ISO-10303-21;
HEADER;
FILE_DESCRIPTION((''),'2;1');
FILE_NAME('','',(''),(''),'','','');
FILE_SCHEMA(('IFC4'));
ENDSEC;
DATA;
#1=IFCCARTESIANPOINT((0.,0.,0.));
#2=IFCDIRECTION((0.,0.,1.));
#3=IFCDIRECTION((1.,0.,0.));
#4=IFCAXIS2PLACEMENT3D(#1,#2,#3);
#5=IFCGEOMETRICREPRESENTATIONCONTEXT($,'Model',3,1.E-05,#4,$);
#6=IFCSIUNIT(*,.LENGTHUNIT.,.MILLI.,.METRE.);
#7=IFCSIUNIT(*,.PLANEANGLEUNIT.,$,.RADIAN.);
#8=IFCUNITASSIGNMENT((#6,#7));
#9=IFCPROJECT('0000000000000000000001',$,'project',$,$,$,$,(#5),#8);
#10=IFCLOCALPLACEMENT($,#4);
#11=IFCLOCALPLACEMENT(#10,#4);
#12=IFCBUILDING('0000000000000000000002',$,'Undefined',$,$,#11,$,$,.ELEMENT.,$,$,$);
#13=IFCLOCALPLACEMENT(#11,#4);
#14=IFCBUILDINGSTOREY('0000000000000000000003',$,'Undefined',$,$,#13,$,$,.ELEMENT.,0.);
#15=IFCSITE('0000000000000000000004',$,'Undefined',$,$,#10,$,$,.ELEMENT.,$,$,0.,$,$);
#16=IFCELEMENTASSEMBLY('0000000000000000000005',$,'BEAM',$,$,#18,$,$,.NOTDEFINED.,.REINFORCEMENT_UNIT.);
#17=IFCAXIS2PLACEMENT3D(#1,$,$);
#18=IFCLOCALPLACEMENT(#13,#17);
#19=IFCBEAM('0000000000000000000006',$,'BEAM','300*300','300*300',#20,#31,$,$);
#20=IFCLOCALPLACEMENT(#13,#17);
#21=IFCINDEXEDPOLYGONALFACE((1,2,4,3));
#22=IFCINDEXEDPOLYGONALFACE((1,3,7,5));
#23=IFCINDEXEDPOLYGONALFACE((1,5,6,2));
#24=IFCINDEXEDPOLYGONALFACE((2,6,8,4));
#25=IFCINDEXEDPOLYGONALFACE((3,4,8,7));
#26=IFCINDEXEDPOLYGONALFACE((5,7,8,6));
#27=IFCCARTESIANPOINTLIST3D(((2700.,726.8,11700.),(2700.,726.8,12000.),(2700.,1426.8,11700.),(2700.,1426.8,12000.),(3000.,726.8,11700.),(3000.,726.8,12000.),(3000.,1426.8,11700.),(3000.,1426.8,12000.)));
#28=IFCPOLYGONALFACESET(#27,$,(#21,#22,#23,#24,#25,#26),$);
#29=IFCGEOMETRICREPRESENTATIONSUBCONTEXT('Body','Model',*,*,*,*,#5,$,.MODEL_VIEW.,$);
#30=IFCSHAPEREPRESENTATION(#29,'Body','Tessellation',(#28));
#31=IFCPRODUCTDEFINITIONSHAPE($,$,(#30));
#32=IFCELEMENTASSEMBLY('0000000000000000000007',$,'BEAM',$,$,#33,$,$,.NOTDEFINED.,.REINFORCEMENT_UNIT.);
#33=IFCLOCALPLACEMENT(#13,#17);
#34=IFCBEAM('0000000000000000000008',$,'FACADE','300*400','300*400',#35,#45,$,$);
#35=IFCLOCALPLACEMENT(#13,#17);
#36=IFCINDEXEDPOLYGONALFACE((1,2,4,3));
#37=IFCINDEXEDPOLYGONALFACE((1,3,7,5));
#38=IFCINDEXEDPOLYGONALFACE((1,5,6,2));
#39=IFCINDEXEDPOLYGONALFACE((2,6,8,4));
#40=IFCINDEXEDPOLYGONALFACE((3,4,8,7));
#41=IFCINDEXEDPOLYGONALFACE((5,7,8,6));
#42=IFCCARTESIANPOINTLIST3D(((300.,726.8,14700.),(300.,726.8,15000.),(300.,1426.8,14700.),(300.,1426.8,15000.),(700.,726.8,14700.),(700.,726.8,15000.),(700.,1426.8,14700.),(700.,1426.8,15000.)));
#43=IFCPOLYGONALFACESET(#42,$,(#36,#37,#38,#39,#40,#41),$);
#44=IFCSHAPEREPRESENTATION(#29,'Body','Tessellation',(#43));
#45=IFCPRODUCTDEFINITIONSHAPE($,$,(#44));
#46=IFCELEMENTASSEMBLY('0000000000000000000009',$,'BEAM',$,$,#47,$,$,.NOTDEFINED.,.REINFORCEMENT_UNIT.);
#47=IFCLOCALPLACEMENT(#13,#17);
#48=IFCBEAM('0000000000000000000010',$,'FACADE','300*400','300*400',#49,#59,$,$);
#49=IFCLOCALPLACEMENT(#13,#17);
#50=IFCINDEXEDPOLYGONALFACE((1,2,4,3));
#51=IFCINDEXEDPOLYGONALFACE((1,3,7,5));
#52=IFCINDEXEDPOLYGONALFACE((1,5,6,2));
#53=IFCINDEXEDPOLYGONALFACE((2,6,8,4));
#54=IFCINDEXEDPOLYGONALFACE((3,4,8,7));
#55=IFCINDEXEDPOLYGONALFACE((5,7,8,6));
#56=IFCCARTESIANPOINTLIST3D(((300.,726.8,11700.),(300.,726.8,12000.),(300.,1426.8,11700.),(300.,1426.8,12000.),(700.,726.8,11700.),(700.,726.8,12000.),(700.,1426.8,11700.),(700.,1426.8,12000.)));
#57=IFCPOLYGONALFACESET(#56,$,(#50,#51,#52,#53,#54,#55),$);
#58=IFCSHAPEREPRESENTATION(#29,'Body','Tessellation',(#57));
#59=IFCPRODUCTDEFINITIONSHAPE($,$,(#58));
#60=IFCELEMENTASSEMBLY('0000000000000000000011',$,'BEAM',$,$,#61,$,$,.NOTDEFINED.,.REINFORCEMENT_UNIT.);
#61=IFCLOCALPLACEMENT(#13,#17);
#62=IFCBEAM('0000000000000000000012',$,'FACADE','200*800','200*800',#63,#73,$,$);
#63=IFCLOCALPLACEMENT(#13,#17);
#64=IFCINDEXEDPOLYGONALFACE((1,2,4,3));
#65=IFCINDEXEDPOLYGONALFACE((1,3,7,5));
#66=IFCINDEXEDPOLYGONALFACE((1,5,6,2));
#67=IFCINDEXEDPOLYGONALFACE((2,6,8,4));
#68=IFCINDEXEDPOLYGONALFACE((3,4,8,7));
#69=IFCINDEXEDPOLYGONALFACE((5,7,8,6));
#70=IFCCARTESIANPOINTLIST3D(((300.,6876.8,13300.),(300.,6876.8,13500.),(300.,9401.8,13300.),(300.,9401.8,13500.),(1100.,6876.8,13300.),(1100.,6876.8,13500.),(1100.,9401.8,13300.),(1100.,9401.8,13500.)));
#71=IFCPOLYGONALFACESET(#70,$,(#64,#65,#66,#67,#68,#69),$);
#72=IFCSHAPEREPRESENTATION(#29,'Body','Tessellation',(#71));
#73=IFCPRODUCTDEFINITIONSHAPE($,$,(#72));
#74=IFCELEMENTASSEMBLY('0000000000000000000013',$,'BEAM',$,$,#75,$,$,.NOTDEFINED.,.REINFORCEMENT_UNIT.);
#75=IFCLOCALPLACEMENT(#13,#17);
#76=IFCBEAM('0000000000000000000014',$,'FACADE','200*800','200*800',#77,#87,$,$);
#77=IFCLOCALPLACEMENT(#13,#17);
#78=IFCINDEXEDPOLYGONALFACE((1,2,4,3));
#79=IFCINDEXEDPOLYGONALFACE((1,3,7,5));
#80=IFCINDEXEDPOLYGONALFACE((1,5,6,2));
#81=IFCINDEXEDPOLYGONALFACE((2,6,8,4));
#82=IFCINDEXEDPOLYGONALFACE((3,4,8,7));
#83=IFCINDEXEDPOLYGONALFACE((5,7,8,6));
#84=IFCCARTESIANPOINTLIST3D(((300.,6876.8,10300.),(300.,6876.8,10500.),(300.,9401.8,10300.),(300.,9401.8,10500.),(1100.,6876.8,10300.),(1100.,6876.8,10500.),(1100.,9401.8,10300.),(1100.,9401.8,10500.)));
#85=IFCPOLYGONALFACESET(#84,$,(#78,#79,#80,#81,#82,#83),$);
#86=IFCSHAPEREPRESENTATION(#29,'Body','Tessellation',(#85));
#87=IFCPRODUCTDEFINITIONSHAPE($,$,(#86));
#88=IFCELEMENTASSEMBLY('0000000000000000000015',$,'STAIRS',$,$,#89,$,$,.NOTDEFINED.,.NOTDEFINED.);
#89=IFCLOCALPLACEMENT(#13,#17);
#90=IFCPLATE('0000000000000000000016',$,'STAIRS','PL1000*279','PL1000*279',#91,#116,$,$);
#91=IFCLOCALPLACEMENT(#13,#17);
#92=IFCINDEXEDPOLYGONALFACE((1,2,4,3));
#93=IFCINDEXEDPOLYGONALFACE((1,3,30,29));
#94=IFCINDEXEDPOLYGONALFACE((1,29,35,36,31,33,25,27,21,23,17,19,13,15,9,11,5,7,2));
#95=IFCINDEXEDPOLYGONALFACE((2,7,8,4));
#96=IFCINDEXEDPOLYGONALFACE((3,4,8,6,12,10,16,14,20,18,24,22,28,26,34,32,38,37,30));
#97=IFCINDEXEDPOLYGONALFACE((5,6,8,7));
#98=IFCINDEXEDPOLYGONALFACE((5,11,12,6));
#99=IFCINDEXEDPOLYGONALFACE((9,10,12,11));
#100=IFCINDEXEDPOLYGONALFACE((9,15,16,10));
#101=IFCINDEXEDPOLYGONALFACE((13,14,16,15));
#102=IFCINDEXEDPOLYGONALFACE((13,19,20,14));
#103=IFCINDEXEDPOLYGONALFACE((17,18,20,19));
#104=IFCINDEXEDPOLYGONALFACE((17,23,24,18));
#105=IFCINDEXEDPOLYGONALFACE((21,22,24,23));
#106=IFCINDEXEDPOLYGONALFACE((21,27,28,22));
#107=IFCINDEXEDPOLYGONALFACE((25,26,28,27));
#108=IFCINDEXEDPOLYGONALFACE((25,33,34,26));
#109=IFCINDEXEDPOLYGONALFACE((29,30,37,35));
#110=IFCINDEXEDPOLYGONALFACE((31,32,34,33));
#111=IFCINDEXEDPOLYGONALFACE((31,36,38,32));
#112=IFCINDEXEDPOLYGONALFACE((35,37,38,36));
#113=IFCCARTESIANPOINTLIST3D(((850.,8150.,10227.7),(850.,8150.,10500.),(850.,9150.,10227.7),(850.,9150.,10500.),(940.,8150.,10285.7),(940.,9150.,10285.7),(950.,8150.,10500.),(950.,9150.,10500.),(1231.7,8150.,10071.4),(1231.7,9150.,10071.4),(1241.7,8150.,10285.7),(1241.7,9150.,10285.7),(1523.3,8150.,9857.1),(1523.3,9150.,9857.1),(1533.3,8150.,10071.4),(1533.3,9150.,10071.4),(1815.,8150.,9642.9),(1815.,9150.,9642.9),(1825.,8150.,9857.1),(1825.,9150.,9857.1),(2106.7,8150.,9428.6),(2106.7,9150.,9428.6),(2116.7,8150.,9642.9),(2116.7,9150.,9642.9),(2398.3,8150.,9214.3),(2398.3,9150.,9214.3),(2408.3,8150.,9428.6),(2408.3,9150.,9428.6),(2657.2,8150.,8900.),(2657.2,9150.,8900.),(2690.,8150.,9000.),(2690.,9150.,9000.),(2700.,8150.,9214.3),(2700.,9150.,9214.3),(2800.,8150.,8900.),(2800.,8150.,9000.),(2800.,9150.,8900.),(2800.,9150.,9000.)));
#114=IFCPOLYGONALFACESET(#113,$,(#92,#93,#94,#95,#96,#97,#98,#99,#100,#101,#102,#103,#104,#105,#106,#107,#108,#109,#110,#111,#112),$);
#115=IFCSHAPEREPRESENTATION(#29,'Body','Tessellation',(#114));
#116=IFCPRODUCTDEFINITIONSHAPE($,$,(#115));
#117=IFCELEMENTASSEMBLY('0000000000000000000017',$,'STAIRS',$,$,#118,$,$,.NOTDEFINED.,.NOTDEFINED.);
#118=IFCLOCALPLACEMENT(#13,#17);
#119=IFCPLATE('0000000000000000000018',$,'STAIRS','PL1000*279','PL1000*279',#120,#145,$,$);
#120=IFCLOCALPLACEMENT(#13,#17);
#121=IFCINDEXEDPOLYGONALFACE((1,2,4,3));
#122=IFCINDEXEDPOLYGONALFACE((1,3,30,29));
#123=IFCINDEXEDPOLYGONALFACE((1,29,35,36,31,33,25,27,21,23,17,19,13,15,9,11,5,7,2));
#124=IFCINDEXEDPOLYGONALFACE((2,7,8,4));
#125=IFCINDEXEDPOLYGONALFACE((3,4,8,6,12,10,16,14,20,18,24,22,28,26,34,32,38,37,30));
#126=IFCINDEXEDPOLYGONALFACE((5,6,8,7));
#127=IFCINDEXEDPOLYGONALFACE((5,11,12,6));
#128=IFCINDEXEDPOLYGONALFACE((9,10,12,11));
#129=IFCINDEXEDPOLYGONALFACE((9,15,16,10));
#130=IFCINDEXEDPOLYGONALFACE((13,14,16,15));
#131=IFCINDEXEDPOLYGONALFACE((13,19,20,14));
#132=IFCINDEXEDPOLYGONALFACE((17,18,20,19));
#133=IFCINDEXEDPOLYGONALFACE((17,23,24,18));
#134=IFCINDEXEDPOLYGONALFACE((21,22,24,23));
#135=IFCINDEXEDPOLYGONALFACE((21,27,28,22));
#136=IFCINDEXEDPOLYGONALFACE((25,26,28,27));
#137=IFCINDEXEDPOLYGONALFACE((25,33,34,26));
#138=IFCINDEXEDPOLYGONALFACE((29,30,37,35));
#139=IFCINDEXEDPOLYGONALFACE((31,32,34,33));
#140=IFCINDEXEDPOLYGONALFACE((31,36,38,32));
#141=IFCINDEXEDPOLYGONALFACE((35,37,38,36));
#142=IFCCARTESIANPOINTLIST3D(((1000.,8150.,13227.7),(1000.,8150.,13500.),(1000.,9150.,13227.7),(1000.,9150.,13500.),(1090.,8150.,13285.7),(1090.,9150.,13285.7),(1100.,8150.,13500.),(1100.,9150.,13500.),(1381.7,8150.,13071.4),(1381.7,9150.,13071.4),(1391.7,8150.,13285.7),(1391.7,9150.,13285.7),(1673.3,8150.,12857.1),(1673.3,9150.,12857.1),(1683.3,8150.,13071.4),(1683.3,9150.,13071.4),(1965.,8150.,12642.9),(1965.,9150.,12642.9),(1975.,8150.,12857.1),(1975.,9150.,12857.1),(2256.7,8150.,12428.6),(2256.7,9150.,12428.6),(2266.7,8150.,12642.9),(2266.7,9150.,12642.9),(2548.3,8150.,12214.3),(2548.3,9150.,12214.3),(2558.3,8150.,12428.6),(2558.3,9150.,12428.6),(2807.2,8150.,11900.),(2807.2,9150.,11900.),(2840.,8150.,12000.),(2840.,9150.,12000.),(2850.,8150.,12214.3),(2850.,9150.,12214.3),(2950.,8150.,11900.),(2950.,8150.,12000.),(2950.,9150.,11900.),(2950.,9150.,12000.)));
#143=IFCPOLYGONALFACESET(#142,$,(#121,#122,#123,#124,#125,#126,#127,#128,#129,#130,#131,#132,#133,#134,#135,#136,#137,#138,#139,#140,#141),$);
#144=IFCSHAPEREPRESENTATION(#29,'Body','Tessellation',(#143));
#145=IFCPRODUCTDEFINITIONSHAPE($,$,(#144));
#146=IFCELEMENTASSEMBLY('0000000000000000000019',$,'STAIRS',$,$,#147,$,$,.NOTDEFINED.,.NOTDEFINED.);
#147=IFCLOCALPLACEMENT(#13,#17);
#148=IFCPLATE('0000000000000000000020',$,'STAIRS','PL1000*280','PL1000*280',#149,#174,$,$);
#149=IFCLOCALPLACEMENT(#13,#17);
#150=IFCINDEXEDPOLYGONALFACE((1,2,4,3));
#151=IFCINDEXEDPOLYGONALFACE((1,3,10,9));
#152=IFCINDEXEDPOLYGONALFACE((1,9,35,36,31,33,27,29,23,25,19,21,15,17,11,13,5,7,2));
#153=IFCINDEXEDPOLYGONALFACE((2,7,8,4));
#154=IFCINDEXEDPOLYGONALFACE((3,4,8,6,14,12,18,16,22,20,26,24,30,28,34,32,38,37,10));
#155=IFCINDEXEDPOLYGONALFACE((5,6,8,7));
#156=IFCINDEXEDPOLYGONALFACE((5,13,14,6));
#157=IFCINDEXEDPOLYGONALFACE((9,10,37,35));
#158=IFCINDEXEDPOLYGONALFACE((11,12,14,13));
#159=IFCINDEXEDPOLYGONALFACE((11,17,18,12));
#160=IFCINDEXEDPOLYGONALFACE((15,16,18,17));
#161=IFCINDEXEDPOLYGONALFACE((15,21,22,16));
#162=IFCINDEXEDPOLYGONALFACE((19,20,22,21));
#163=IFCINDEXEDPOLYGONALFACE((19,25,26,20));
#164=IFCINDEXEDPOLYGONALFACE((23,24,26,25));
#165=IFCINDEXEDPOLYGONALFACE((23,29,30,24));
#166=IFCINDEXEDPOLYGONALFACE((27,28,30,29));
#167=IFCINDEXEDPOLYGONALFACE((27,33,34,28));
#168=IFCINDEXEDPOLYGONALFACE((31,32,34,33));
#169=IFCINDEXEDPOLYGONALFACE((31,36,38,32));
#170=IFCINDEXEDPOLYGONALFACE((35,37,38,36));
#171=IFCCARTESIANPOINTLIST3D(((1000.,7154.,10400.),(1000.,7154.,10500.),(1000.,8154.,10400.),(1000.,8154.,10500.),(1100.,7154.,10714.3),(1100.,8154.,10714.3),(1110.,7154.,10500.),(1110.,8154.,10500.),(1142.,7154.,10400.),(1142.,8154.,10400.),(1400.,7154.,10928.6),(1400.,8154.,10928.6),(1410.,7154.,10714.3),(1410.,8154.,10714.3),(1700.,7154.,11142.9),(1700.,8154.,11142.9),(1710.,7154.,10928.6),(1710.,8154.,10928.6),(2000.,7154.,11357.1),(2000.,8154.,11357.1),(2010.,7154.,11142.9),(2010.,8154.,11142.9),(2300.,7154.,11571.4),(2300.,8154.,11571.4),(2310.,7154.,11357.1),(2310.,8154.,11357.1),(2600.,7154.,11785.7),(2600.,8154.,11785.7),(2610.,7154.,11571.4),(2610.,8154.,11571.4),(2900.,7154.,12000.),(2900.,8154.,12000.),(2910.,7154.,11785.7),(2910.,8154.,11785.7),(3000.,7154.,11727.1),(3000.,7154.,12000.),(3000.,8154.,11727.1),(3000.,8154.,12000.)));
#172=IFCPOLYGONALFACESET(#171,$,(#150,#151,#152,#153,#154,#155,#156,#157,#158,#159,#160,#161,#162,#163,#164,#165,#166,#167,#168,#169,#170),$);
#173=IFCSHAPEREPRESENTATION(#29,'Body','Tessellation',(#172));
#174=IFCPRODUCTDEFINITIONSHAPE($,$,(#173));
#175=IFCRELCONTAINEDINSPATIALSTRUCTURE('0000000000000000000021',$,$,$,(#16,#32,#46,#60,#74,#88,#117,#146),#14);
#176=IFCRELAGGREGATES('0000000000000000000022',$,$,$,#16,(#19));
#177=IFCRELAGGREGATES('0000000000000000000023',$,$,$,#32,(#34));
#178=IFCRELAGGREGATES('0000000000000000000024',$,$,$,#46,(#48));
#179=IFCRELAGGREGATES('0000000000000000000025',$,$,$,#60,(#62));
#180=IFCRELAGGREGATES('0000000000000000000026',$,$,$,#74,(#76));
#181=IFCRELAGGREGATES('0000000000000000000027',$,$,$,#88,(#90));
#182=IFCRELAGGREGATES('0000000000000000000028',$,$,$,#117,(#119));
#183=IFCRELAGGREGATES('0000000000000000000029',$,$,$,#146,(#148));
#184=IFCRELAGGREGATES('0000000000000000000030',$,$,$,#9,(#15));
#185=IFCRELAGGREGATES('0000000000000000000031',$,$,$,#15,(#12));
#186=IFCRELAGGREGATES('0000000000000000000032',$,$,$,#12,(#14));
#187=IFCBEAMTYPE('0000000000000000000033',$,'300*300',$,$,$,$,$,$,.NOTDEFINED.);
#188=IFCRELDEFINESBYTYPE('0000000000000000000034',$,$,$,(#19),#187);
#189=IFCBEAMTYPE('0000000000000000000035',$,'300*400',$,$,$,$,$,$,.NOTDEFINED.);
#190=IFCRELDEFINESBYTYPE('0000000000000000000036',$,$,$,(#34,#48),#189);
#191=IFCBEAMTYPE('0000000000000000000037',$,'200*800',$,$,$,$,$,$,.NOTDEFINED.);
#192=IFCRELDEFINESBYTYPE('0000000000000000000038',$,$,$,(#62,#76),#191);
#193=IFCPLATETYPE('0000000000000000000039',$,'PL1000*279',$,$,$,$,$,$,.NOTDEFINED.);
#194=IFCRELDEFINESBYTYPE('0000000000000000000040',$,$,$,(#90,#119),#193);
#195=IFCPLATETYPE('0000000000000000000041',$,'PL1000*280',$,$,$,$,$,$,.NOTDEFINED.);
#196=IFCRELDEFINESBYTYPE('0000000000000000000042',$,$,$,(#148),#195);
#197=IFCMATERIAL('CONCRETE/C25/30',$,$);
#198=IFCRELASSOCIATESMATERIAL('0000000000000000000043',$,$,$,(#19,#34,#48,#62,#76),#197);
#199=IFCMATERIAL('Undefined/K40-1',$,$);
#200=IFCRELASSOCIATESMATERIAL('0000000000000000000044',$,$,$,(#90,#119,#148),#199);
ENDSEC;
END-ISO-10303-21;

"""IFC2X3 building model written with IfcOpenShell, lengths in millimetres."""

from ifc_helpers import new_model, si_unit, frame, origin_with_axes, origin_2d_with_axis, place, context, subcontext, project, spatial, polyline, rectangle, outline, extrude, material, type_object, element, aggregate, save


model = new_model("IFC2X3")

# Units and contexts
model_context = context("Model", 3, precision=1e-05, world=origin_with_axes())
body_context = subcontext(model_context, "Body", "Model", "MODEL_VIEW")
ifc_project = project(units=[si_unit("LENGTHUNIT", "METRE", prefix="MILLI"), si_unit("PLANEANGLEUNIT", "RADIAN")], contexts=[model_context])

# Site, building, storey
site_placement = place(None, origin_with_axes())
site = spatial("IfcSite", under=ifc_project, at=site_placement, Name="Undefined", CompositionType="ELEMENT", RefElevation=0.0)
building_placement = place(site_placement, origin_with_axes())
building = spatial("IfcBuilding", under=site, at=building_placement, Name="Undefined", CompositionType="ELEMENT")
storey_placement = place(building_placement, origin_with_axes())
storey = spatial("IfcBuildingStorey", under=building, at=storey_placement, Name="Undefined", CompositionType="ELEMENT", Elevation=0.0)

# Shared definitions
ifc_material_1 = material(Name="CONCRETE/C25/30")

# Element assemblies, beams
beam_type_1 = type_object("IfcBeamType", Name="300*300", PredefinedType="NOTDEFINED")
assembly_1_placement = place(storey_placement, origin_with_axes())
assembly_1 = element("IfcElementAssembly", 1, at=assembly_1_placement, inside=storey, Name="BEAM", AssemblyPlace="NOTDEFINED", PredefinedType="REINFORCEMENT_UNIT")
beam_1_placement = place(assembly_1_placement, frame((2850.0, 1426.8, 11850.0), z_axis=(0.0, 0.0, 1.0), x_axis=(0.0, -1.0, 0.0)))
beam_1 = element("IfcBeam", 2, at=beam_1_placement, type_object=beam_type_1, material=ifc_material_1, Name="BEAM", Description="300*300", ObjectType="300*300", context=body_context, shape_type="SweptSolid", body=[
    extrude(rectangle(XDim=300.0, YDim=300.0, at=origin_2d_with_axis()), frame((700.0, 0.0, 0.0), z_axis=(-1.0, 0.0, 0.0), x_axis=(0.0, -1.0, 0.0)), (0.0, 0.0, 1.0), 700.0),
])
aggregate(assembly_1, [beam_1])
assembly_2_placement = place(storey_placement, origin_with_axes())
assembly_2 = element("IfcElementAssembly", 3, at=assembly_2_placement, inside=storey, Name="BEAM", AssemblyPlace="NOTDEFINED", PredefinedType="REINFORCEMENT_UNIT")
beam_type_2 = type_object("IfcBeamType", Name="300*400", PredefinedType="NOTDEFINED")
beam_2_placement = place(assembly_2_placement, frame((500.0, 1426.8, 14850.0), z_axis=(0.0, 0.0, 1.0), x_axis=(0.0, -1.0, 0.0)))
beam_2 = element("IfcBeam", 4, at=beam_2_placement, type_object=beam_type_2, material=ifc_material_1, Name="FACADE", Description="300*400", ObjectType="300*400", context=body_context, shape_type="SweptSolid", body=[
    extrude(rectangle(XDim=400.0, YDim=300.0, at=origin_2d_with_axis()), frame((700.0, 0.0, 0.0), z_axis=(-1.0, 0.0, 0.0), x_axis=(0.0, -1.0, 0.0)), (0.0, 0.0, 1.0), 700.0),
])
aggregate(assembly_2, [beam_2])
assembly_3_placement = place(storey_placement, origin_with_axes())
assembly_3 = element("IfcElementAssembly", 5, at=assembly_3_placement, inside=storey, Name="BEAM", AssemblyPlace="NOTDEFINED", PredefinedType="REINFORCEMENT_UNIT")
beam_3_placement = place(assembly_3_placement, frame((500.0, 1426.8, 11850.0), z_axis=(0.0, 0.0, 1.0), x_axis=(0.0, -1.0, 0.0)))
beam_3 = element("IfcBeam", 6, at=beam_3_placement, type_object=beam_type_2, material=ifc_material_1, Name="FACADE", Description="300*400", ObjectType="300*400", context=body_context, shape_type="SweptSolid", body=[
    extrude(rectangle(XDim=400.0, YDim=300.0, at=origin_2d_with_axis()), frame((700.0, 0.0, 0.0), z_axis=(-1.0, 0.0, 0.0), x_axis=(0.0, -1.0, 0.0)), (0.0, 0.0, 1.0), 700.0),
])
aggregate(assembly_3, [beam_3])
assembly_4_placement = place(storey_placement, origin_with_axes())
assembly_4 = element("IfcElementAssembly", 7, at=assembly_4_placement, inside=storey, Name="BEAM", AssemblyPlace="NOTDEFINED", PredefinedType="REINFORCEMENT_UNIT")
beam_type_3 = type_object("IfcBeamType", Name="200*800", PredefinedType="NOTDEFINED")
beam_4_placement = place(assembly_4_placement, frame((700.0, 9401.8, 13400.0), z_axis=(0.0, 0.0, 1.0), x_axis=(0.0, -1.0, 0.0)))
beam_4 = element("IfcBeam", 8, at=beam_4_placement, type_object=beam_type_3, material=ifc_material_1, Name="FACADE", Description="200*800", ObjectType="200*800", context=body_context, shape_type="SweptSolid", body=[
    extrude(rectangle(XDim=800.0, YDim=200.0, at=origin_2d_with_axis()), frame((2525.0, 0.0, 0.0), z_axis=(-1.0, 0.0, 0.0), x_axis=(0.0, -1.0, 0.0)), (0.0, 0.0, 1.0), 2525.0),
])
aggregate(assembly_4, [beam_4])
assembly_5_placement = place(storey_placement, origin_with_axes())
assembly_5 = element("IfcElementAssembly", 9, at=assembly_5_placement, inside=storey, Name="BEAM", AssemblyPlace="NOTDEFINED", PredefinedType="REINFORCEMENT_UNIT")
beam_5_placement = place(assembly_5_placement, frame((700.0, 9401.8, 10400.0), z_axis=(0.0, 0.0, 1.0), x_axis=(0.0, -1.0, 0.0)))
beam_5 = element("IfcBeam", 10, at=beam_5_placement, type_object=beam_type_3, material=ifc_material_1, Name="FACADE", Description="200*800", ObjectType="200*800", context=body_context, shape_type="SweptSolid", body=[
    extrude(rectangle(XDim=800.0, YDim=200.0, at=origin_2d_with_axis()), frame((2525.0, 0.0, 0.0), z_axis=(-1.0, 0.0, 0.0), x_axis=(0.0, -1.0, 0.0)), (0.0, 0.0, 1.0), 2525.0),
])
aggregate(assembly_5, [beam_5])

# Element assemblies, plates
assembly_6_placement = place(storey_placement, origin_with_axes())
assembly_6 = element("IfcElementAssembly", 11, at=assembly_6_placement, inside=storey, Name="STAIRS", AssemblyPlace="NOTDEFINED", PredefinedType="NOTDEFINED")
ifc_material_2 = material(Name="Undefined/K40-1")
plate_type_1 = type_object("IfcPlateType", Name="PL1000*279", PredefinedType="NOTDEFINED")
plate_1_placement = place(assembly_6_placement, frame((2690.0, 8650.0, 9000.0), z_axis=(0.0, 1.0, 0.0), x_axis=(1.0, 0.0, 0.0)))
plate_1 = element("IfcPlate", 12, at=plate_1_placement, type_object=plate_type_1, material=ifc_material_2, Name="STAIRS", Description="PL1000*279", ObjectType="PL1000*279", context=body_context, shape_type="SweptSolid", body=[
    extrude(outline(polyline([(0.0, 0.0), (110.0, 0.0), (110.0, 100.0), (-32.8, 100.0), (-1840.0, -1227.7), (-1840.0, -1500.0), (-1740.0, -1500.0), (-1750.0, -1285.7), (-1448.3, -1285.7), (-1458.3, -1071.4), (-1156.7, -1071.4), (-1166.7, -857.1), (-865.0, -857.1), (-875.0, -642.9), (-573.3, -642.9), (-583.3, -428.6), (-281.7, -428.6), (-291.7, -214.3), (10.0, -214.3), (0.0, 0.0), (0.0, 0.0)])), frame((0.0, 0.0, -500.0), z_axis=(0.0, 0.0, 1.0), x_axis=(1.0, 0.0, 0.0)), (0.0, 0.0, 1.0), 1000.0),
])
aggregate(assembly_6, [plate_1])
assembly_7_placement = place(storey_placement, origin_with_axes())
assembly_7 = element("IfcElementAssembly", 13, at=assembly_7_placement, inside=storey, Name="STAIRS", AssemblyPlace="NOTDEFINED", PredefinedType="NOTDEFINED")
plate_2_placement = place(assembly_7_placement, frame((2840.0, 8650.0, 12000.0), z_axis=(0.0, 1.0, 0.0), x_axis=(1.0, 0.0, 0.0)))
plate_2 = element("IfcPlate", 14, at=plate_2_placement, type_object=plate_type_1, material=ifc_material_2, Name="STAIRS", Description="PL1000*279", ObjectType="PL1000*279", context=body_context, shape_type="SweptSolid", body=[
    extrude(outline(polyline([(0.0, 0.0), (110.0, 0.0), (110.0, 100.0), (-32.8, 100.0), (-1840.0, -1227.7), (-1840.0, -1500.0), (-1740.0, -1500.0), (-1750.0, -1285.7), (-1448.3, -1285.7), (-1458.3, -1071.4), (-1156.7, -1071.4), (-1166.7, -857.1), (-865.0, -857.1), (-875.0, -642.9), (-573.3, -642.9), (-583.3, -428.6), (-281.7, -428.6), (-291.7, -214.3), (10.0, -214.3), (0.0, 0.0), (0.0, 0.0)])), frame((0.0, 0.0, -500.0), z_axis=(0.0, 0.0, 1.0), x_axis=(1.0, 0.0, 0.0)), (0.0, 0.0, 1.0), 1000.0),
])
aggregate(assembly_7, [plate_2])
assembly_8_placement = place(storey_placement, origin_with_axes())
assembly_8 = element("IfcElementAssembly", 15, at=assembly_8_placement, inside=storey, Name="STAIRS", AssemblyPlace="NOTDEFINED", PredefinedType="NOTDEFINED")
plate_type_2 = type_object("IfcPlateType", Name="PL1000*280", PredefinedType="NOTDEFINED")
plate_3_placement = place(assembly_8_placement, frame((1110.0, 7654.0, 10500.0), z_axis=(0.0, -1.0, 0.0), x_axis=(-1.0, 0.0, 0.0)))
plate_3 = element("IfcPlate", 16, at=plate_3_placement, type_object=plate_type_2, material=ifc_material_2, Name="STAIRS", Description="PL1000*280", ObjectType="PL1000*280", context=body_context, shape_type="SweptSolid", body=[
    extrude(outline(polyline([(0.0, 0.0), (110.0, 0.0), (110.0, 100.0), (-32.0, 100.0), (-1890.0, -1227.1), (-1890.0, -1500.0), (-1790.0, -1500.0), (-1800.0, -1285.7), (-1490.0, -1285.7), (-1500.0, -1071.4), (-1190.0, -1071.4), (-1200.0, -857.1), (-890.0, -857.1), (-900.0, -642.9), (-590.0, -642.9), (-600.0, -428.6), (-290.0, -428.6), (-300.0, -214.3), (10.0, -214.3), (0.0, 0.0), (0.0, 0.0)])), frame((0.0, 0.0, -500.0), z_axis=(0.0, 0.0, 1.0), x_axis=(1.0, 0.0, 0.0)), (0.0, 0.0, 1.0), 1000.0),
])
aggregate(assembly_8, [plate_3])

save(model, "model.ifc")
